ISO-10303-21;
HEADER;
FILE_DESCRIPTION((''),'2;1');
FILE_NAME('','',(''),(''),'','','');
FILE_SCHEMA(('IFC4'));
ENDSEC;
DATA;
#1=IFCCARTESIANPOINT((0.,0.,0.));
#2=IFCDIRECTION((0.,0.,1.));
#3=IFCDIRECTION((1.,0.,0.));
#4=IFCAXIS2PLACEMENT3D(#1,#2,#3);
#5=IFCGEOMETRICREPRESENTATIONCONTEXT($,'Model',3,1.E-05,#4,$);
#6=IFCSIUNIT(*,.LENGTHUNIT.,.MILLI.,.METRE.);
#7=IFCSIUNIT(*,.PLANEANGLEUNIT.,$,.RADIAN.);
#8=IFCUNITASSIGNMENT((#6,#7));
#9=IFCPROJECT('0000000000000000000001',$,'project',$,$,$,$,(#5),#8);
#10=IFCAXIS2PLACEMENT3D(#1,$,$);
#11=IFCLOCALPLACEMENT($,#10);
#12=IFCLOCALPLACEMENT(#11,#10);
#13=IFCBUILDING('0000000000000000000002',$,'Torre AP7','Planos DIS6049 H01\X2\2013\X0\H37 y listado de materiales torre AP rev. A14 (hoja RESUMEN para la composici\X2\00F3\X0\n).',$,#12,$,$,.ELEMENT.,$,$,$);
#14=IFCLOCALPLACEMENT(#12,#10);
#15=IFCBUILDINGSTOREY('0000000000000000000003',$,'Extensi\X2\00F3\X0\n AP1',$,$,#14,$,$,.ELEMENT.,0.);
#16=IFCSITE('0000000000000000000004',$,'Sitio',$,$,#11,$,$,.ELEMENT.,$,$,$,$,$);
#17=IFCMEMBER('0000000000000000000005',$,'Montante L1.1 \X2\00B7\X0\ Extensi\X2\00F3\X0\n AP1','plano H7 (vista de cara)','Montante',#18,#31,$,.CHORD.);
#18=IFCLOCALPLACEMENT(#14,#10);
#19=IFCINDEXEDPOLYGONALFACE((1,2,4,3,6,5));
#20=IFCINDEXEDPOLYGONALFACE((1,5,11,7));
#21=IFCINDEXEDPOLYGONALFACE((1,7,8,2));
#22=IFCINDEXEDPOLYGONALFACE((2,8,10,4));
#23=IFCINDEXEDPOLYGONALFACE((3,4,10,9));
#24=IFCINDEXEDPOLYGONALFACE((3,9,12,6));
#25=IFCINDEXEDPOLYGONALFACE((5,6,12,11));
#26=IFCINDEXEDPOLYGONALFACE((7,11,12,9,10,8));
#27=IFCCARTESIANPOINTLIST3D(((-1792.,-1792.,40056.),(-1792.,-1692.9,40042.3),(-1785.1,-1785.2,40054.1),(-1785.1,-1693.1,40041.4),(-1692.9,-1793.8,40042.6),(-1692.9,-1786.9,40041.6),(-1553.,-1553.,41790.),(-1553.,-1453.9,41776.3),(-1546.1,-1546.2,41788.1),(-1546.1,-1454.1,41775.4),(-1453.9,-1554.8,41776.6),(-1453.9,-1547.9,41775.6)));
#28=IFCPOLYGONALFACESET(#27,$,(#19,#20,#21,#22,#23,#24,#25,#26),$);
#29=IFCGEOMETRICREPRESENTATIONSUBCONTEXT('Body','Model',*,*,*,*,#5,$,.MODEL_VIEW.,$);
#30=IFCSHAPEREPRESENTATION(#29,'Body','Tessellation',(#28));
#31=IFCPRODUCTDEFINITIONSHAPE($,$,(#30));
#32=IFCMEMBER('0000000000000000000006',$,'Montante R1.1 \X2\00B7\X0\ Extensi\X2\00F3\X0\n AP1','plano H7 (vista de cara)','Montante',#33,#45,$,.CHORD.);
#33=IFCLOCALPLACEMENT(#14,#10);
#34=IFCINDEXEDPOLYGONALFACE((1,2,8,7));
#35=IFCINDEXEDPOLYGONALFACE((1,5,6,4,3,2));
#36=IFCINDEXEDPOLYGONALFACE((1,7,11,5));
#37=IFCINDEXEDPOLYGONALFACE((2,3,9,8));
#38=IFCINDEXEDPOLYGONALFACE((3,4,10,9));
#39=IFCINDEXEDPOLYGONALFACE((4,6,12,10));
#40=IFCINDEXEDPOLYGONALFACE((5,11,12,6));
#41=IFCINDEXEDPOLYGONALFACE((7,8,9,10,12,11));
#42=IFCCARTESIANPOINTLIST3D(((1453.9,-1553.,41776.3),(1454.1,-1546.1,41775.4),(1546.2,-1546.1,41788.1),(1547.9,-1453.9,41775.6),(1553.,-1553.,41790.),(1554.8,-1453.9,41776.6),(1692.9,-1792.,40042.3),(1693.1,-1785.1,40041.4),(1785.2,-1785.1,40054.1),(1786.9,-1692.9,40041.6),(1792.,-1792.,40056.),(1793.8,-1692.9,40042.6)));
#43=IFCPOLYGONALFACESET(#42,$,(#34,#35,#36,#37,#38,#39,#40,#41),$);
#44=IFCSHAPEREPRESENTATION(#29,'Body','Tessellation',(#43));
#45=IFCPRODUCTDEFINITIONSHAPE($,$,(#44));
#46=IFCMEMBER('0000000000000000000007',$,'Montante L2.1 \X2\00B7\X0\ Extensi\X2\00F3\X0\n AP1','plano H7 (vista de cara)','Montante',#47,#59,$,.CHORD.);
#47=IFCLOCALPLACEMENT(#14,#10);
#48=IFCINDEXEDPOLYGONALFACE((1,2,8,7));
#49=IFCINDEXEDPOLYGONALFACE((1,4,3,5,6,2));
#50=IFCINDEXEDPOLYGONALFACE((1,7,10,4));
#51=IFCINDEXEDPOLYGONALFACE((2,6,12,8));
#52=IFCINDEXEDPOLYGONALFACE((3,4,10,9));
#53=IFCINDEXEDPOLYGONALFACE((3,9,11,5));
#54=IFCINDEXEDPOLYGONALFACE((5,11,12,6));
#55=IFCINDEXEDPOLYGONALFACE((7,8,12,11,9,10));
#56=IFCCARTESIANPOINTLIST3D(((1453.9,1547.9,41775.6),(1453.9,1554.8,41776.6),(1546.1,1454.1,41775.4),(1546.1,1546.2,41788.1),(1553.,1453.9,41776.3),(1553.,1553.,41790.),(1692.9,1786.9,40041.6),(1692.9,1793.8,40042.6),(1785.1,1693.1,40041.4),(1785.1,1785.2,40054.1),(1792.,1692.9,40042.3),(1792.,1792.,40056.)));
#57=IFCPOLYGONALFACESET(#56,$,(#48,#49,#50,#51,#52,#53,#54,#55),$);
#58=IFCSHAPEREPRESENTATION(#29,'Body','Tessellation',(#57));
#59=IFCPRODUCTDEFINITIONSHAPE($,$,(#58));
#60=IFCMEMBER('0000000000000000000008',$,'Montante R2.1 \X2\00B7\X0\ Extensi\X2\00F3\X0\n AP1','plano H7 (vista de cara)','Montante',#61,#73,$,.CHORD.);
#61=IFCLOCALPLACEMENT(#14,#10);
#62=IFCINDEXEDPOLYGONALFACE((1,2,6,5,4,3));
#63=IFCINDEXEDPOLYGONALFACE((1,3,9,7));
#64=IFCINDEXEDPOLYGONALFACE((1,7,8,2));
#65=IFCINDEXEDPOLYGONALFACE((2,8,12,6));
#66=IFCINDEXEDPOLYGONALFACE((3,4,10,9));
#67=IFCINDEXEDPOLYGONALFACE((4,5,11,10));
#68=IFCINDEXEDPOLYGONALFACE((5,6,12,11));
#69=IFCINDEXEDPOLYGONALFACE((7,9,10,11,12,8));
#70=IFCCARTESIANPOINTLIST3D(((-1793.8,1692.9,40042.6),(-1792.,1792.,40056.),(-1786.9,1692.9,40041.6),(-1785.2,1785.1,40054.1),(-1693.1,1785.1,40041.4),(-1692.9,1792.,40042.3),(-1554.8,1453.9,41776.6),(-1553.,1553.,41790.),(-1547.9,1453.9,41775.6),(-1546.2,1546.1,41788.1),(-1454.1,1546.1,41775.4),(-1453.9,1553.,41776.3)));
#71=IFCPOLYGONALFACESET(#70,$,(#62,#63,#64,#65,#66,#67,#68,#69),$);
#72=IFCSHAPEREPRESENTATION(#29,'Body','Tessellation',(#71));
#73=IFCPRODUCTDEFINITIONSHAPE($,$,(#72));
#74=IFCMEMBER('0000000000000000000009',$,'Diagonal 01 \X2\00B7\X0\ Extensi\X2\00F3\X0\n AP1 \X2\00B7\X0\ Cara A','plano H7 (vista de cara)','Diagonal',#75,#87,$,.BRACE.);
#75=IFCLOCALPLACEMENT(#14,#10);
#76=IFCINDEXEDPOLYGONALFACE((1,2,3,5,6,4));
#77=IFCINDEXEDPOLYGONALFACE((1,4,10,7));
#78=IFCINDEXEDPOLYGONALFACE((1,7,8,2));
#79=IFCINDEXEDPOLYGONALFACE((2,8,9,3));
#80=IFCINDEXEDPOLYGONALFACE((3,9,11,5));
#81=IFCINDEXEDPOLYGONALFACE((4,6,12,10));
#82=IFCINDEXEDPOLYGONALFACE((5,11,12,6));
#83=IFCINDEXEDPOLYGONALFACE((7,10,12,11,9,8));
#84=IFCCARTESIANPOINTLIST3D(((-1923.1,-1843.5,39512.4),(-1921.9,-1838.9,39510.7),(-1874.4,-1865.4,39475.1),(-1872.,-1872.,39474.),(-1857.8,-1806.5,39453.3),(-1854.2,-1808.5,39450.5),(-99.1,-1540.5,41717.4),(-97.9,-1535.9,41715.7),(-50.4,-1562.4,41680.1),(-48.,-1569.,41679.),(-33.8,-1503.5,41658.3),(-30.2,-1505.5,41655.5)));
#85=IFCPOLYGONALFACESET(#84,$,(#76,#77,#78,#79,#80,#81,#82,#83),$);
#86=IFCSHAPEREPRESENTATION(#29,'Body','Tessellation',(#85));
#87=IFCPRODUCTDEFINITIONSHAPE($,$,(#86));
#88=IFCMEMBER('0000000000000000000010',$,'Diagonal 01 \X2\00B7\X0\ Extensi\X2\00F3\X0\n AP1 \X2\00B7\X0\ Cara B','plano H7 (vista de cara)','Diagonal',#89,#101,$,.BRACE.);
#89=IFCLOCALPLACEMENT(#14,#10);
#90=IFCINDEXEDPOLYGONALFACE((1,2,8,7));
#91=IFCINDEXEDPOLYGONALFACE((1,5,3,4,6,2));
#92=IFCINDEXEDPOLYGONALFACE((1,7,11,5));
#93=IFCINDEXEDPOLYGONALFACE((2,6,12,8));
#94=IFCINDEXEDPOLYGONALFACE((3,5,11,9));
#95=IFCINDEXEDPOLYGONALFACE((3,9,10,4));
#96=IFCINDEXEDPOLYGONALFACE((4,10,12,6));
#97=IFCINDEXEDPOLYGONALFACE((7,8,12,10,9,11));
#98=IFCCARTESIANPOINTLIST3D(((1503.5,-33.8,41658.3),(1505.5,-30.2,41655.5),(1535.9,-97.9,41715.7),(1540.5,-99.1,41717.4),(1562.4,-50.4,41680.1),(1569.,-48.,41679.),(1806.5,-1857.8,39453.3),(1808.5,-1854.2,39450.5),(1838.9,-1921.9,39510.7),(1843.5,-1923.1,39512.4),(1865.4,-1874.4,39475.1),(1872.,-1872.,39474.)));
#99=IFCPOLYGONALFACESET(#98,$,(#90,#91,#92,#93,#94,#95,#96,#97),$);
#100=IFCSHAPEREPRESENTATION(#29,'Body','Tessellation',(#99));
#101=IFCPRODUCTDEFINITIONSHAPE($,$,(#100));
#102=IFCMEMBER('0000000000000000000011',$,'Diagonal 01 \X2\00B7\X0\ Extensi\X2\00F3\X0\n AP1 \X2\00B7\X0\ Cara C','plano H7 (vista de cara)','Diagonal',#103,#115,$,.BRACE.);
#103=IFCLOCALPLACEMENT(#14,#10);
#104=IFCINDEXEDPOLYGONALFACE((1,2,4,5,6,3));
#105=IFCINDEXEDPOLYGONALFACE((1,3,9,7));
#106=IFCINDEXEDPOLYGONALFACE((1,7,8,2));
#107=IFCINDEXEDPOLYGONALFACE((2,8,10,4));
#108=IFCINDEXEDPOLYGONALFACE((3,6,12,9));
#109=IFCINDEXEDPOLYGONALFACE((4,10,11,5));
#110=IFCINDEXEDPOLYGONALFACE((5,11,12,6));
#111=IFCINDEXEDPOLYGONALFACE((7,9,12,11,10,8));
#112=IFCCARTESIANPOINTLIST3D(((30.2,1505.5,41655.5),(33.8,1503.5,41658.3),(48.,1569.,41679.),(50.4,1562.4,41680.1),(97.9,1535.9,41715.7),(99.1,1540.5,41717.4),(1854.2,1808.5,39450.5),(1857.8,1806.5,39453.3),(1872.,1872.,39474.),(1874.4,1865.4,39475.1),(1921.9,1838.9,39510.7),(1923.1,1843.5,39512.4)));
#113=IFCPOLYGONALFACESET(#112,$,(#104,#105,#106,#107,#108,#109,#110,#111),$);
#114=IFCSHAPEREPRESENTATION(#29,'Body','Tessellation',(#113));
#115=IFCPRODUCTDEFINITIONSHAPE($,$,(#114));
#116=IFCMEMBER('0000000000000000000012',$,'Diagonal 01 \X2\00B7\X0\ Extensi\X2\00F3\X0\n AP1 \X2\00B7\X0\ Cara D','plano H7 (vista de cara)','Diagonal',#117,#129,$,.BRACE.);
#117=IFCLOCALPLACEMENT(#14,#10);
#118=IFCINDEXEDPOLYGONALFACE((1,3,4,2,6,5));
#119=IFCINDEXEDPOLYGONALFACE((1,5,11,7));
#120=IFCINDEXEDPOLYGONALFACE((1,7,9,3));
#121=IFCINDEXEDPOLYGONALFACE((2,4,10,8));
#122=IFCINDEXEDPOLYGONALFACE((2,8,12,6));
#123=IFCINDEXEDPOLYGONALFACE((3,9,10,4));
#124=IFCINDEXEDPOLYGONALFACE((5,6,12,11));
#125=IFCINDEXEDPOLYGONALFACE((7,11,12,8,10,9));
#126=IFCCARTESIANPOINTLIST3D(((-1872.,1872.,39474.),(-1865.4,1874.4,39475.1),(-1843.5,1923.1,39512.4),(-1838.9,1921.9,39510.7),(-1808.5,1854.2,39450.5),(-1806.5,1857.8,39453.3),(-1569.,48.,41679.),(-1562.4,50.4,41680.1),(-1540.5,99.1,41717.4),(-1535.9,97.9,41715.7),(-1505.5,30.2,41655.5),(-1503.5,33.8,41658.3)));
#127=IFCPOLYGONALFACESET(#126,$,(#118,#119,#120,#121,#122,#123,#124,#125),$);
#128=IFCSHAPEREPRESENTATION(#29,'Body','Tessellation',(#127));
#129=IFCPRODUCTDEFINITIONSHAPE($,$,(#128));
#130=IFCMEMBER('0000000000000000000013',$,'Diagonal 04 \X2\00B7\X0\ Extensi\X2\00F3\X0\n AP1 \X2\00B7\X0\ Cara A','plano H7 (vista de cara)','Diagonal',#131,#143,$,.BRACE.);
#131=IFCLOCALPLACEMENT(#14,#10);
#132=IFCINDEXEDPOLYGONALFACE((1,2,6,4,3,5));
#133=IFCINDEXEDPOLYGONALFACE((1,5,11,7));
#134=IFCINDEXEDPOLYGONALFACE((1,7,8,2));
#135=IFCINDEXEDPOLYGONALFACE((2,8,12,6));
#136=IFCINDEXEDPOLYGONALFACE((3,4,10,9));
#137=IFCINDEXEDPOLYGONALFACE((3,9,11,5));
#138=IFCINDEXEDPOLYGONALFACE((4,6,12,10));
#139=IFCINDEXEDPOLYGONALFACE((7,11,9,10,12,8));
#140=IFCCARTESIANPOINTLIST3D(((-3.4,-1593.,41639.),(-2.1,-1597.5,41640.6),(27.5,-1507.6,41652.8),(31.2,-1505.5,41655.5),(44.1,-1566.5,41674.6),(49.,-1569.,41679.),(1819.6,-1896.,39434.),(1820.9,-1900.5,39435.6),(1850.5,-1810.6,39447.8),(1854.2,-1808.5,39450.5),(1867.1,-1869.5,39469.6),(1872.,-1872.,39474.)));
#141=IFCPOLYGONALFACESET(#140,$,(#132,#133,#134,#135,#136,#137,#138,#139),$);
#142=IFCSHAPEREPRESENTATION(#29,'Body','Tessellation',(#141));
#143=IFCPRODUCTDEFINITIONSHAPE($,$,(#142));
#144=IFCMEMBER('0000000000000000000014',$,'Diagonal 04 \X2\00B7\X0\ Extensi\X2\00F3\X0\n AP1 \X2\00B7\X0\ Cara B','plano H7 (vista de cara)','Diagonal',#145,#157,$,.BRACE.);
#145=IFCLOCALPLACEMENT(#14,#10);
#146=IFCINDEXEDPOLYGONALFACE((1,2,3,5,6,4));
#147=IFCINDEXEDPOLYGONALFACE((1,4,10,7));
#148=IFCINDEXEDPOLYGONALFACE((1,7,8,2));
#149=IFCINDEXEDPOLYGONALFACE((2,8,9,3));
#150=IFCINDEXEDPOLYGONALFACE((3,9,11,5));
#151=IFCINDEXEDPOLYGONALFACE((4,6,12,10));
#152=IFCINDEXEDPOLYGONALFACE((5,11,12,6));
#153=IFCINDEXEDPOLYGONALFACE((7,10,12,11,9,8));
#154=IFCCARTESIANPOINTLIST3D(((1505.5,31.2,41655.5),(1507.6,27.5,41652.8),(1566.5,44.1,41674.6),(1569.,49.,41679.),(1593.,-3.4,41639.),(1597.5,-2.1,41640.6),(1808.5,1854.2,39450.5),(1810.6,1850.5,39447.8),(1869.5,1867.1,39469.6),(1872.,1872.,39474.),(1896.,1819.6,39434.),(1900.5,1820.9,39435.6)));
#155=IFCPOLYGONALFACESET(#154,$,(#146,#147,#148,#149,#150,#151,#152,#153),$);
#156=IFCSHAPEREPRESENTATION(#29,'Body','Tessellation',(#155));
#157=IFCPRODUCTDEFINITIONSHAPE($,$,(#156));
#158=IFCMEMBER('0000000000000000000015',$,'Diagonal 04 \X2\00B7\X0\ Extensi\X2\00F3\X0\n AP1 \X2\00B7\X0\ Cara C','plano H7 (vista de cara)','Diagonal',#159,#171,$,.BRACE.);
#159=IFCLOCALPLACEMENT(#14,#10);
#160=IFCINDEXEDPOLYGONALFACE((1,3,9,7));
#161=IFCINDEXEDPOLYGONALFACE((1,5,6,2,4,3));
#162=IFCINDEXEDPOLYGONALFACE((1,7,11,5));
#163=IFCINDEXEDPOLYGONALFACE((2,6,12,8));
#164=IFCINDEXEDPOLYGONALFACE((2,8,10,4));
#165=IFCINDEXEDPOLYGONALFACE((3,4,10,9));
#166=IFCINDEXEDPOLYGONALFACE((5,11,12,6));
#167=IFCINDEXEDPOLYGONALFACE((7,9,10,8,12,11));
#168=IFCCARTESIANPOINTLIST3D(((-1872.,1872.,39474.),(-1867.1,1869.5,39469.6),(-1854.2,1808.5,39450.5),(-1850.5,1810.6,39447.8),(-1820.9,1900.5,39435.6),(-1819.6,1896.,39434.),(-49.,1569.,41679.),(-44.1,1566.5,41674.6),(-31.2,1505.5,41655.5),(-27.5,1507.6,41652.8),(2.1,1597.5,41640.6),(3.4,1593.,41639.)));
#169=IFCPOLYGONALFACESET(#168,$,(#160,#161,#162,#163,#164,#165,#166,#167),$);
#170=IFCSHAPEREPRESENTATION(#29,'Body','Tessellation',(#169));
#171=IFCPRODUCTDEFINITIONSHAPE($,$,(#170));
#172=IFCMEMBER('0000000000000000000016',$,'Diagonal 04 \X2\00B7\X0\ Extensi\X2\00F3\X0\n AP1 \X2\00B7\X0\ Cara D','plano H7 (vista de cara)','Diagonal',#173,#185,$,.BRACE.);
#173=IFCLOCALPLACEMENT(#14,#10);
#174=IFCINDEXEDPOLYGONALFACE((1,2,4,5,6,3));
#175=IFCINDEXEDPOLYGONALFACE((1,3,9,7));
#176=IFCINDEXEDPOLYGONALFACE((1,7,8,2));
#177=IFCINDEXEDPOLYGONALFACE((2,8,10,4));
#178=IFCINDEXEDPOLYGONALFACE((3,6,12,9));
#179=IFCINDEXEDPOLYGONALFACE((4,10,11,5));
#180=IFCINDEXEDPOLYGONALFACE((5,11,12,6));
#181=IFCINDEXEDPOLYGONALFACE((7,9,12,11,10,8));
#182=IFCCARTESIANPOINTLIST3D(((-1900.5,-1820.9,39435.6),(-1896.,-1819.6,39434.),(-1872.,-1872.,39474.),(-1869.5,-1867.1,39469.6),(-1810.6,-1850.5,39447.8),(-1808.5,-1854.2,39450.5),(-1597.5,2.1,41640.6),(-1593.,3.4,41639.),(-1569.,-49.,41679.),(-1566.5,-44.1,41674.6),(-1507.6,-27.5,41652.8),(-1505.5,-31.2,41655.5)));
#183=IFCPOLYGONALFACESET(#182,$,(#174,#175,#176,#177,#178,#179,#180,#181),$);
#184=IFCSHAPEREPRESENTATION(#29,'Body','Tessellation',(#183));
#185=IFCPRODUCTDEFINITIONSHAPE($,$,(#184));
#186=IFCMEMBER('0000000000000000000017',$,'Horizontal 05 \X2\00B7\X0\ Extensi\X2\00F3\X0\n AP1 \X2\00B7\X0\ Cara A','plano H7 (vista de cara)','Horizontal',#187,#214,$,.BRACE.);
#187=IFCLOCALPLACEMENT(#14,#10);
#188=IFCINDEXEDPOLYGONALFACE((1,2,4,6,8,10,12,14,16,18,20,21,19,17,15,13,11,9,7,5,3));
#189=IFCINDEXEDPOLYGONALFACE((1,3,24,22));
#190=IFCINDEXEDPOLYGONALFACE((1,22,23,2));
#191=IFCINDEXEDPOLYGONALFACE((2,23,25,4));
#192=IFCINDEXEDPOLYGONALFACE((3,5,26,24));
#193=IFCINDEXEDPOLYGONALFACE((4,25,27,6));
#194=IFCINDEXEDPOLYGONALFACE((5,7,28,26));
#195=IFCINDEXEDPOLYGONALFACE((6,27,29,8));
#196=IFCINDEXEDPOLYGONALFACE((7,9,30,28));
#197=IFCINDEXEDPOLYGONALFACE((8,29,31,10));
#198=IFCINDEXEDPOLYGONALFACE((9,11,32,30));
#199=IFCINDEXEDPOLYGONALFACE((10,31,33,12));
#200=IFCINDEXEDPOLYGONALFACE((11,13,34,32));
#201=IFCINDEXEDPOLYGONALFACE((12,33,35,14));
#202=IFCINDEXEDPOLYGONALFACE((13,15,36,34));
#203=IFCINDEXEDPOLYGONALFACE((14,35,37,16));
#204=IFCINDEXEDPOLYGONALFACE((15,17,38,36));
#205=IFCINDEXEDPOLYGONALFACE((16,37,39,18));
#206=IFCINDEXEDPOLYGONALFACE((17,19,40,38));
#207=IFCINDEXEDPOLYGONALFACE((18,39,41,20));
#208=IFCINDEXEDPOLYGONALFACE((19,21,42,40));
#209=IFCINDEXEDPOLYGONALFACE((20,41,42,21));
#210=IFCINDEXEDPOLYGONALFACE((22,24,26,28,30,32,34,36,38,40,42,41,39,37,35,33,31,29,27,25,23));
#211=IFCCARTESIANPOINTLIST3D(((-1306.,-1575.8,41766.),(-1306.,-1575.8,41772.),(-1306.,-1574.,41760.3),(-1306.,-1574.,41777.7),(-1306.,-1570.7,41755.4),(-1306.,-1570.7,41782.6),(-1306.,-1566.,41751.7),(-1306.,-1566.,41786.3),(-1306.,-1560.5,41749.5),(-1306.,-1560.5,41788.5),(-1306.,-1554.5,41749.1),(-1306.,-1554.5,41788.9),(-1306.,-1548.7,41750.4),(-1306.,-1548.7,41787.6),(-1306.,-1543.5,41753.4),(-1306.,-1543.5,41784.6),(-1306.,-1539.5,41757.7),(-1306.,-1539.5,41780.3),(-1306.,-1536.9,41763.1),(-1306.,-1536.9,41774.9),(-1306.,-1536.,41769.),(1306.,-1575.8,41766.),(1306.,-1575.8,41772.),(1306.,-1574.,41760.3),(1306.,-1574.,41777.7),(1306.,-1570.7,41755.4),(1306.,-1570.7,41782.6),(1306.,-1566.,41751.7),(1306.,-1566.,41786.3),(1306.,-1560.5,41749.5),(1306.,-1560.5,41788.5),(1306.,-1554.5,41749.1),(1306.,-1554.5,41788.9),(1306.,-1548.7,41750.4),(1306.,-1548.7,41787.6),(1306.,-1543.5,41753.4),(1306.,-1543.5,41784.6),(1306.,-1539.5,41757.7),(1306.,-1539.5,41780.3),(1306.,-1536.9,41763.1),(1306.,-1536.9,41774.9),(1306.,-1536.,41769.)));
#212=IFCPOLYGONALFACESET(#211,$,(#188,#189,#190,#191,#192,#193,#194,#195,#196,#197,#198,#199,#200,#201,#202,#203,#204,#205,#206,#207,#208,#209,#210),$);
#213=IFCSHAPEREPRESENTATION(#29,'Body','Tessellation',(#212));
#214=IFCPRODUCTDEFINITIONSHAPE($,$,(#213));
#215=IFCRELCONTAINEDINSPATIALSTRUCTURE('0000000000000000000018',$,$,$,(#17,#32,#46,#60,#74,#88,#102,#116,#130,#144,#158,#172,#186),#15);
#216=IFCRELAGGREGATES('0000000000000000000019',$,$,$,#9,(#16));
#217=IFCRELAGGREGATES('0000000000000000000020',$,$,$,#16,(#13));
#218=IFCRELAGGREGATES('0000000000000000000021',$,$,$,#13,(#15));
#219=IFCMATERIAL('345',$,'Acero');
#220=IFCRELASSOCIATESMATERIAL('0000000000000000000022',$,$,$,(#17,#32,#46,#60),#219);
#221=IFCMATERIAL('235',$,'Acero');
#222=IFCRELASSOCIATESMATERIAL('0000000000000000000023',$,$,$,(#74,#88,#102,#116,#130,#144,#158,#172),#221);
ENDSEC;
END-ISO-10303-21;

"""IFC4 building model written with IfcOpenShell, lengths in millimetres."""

from ifc_helpers import new_model, si_unit, frame, frame_2d, origin, origin_with_axes, place, context, subcontext, project, spatial, circle, l_section, extrude, material, element, save


model = new_model("IFC4")

# Units and contexts
model_context = context("Model", 3, precision=1e-05, world=origin_with_axes())
body_context = subcontext(model_context, "Body", "Model", "MODEL_VIEW")
ifc_project = project(units=[si_unit("LENGTHUNIT", "METRE", prefix="MILLI"), si_unit("PLANEANGLEUNIT", "RADIAN")], contexts=[model_context])

# Site, building, storey
site_placement = place(None, origin())
site = spatial("IfcSite", under=ifc_project, at=site_placement, Name="Sitio", CompositionType="ELEMENT")
building_placement = place(site_placement, origin())
building = spatial("IfcBuilding", under=site, at=building_placement, Name="Torre AP7", Description="Planos DIS6049 H01–H37 y listado de materiales torre AP rev. A14 (hoja RESUMEN para la composición).", CompositionType="ELEMENT")
storey_placement = place(building_placement, origin())
storey = spatial("IfcBuildingStorey", under=building, at=storey_placement, Name="Extensión AP1", CompositionType="ELEMENT", Elevation=0.0)

# Members
ifc_material_1 = material(Name="345", Category="Acero")
for number, where, z_axis, x_axis, name in (
    (1, (-1792.0, -1792.0, 40056.0), (0.135285, 0.135285, 0.981527), (0.990807, -0.018472, -0.134018), "Montante L1.1 · Extensión AP1"),
    (2, (1792.0, -1792.0, 40056.0), (-0.135285, 0.135285, 0.981527), (0.018472, 0.990807, -0.134018), "Montante R1.1 · Extensión AP1"),
    (3, (1792.0, 1792.0, 40056.0), (-0.135285, -0.135285, 0.981527), (-0.990807, 0.018472, -0.134018), "Montante L2.1 · Extensión AP1"),
    (4, (-1792.0, 1792.0, 40056.0), (0.135285, -0.135285, 0.981527), (-0.018472, -0.990807, -0.134018), "Montante R2.1 · Extensión AP1"),
):
    element("IfcMember", number, at=place(storey_placement, frame(where, z_axis=z_axis, x_axis=x_axis)), inside=storey, material=ifc_material_1, Name=name, Description="plano H7 (vista de cara)", ObjectType="Montante", PredefinedType="CHORD", context=body_context, shape_type="SweptSolid", body=[
        extrude(l_section(Depth=100.0, Width=100.0, Thickness=7.0, at=frame_2d((50.0, 50.0))), None, (0.0, 0.0, 1.0), 1766.6),
    ])
ifc_material_2 = material(Name="235", Category="Acero")
for number, where, z_axis, x_axis, name in (
    (5, (-1872.0, -1872.0, 39474.0), (0.633853, 0.105295, 0.766253), (0.25455, 0.907102, -0.335216), "Diagonal 01 · Extensión AP1 · Cara A"),
    (6, (1872.0, -1872.0, 39474.0), (-0.105295, 0.633853, 0.766253), (-0.907102, 0.25455, -0.335216), "Diagonal 01 · Extensión AP1 · Cara B"),
    (7, (1872.0, 1872.0, 39474.0), (-0.633853, -0.105295, 0.766253), (-0.25455, -0.907102, -0.335216), "Diagonal 01 · Extensión AP1 · Cara C"),
    (8, (-1872.0, 1872.0, 39474.0), (0.105295, -0.633853, 0.766253), (0.907102, -0.25455, -0.335216), "Diagonal 01 · Extensión AP1 · Cara D"),
):
    element("IfcMember", number, at=place(storey_placement, frame(where, z_axis=z_axis, x_axis=x_axis)), inside=storey, material=ifc_material_2, Name=name, Description="plano H7 (vista de cara)", ObjectType="Diagonal", PredefinedType="BRACE", context=body_context, shape_type="SweptSolid", body=[
        extrude(l_section(Depth=70.0, Width=70.0, Thickness=5.0, at=frame_2d((35.0, 35.0))), None, (0.0, 0.0, 1.0), 2877.6),
    ])
for number, where, z_axis, x_axis, name in (
    (9, (1872.0, -1872.0, 39474.0), (-0.633645, 0.105318, 0.766422), (-0.254835, 0.906984, -0.33532), "Diagonal 04 · Extensión AP1 · Cara A"),
    (10, (1872.0, 1872.0, 39474.0), (-0.105318, -0.633645, 0.766422), (-0.906984, -0.254835, -0.33532), "Diagonal 04 · Extensión AP1 · Cara B"),
    (11, (-1872.0, 1872.0, 39474.0), (0.633645, -0.105318, 0.766422), (0.254835, -0.906984, -0.33532), "Diagonal 04 · Extensión AP1 · Cara C"),
    (12, (-1872.0, -1872.0, 39474.0), (0.105318, 0.633645, 0.766422), (0.906984, 0.254835, -0.33532), "Diagonal 04 · Extensión AP1 · Cara D"),
):
    element("IfcMember", number, at=place(storey_placement, frame(where, z_axis=z_axis, x_axis=x_axis)), inside=storey, material=ifc_material_2, Name=name, Description="plano H7 (vista de cara)", ObjectType="Diagonal", PredefinedType="BRACE", context=body_context, shape_type="SweptSolid", body=[
        extrude(l_section(Depth=70.0, Width=70.0, Thickness=5.0, at=frame_2d((35.0, 35.0))), None, (0.0, 0.0, 1.0), 2877.0),
    ])
for number, where, z_axis, x_axis, name in (
    (13, (1306.0, -1556.0, 41769.0), (-1.0, 0.0, 0.0), (0.0, 1.0, 0.0), "Horizontal 05 · Extensión AP1 · Cara A"),
):
    element("IfcMember", number, at=place(storey_placement, frame(where, z_axis=z_axis, x_axis=x_axis)), inside=storey, Name=name, Description="plano H7 (vista de cara)", ObjectType="Horizontal", PredefinedType="BRACE", context=body_context, shape_type="SweptSolid", body=[
        extrude(circle(Radius=20.0), None, (0.0, 0.0, 1.0), 2612.0),
    ])

save(model, "model.ifc")
